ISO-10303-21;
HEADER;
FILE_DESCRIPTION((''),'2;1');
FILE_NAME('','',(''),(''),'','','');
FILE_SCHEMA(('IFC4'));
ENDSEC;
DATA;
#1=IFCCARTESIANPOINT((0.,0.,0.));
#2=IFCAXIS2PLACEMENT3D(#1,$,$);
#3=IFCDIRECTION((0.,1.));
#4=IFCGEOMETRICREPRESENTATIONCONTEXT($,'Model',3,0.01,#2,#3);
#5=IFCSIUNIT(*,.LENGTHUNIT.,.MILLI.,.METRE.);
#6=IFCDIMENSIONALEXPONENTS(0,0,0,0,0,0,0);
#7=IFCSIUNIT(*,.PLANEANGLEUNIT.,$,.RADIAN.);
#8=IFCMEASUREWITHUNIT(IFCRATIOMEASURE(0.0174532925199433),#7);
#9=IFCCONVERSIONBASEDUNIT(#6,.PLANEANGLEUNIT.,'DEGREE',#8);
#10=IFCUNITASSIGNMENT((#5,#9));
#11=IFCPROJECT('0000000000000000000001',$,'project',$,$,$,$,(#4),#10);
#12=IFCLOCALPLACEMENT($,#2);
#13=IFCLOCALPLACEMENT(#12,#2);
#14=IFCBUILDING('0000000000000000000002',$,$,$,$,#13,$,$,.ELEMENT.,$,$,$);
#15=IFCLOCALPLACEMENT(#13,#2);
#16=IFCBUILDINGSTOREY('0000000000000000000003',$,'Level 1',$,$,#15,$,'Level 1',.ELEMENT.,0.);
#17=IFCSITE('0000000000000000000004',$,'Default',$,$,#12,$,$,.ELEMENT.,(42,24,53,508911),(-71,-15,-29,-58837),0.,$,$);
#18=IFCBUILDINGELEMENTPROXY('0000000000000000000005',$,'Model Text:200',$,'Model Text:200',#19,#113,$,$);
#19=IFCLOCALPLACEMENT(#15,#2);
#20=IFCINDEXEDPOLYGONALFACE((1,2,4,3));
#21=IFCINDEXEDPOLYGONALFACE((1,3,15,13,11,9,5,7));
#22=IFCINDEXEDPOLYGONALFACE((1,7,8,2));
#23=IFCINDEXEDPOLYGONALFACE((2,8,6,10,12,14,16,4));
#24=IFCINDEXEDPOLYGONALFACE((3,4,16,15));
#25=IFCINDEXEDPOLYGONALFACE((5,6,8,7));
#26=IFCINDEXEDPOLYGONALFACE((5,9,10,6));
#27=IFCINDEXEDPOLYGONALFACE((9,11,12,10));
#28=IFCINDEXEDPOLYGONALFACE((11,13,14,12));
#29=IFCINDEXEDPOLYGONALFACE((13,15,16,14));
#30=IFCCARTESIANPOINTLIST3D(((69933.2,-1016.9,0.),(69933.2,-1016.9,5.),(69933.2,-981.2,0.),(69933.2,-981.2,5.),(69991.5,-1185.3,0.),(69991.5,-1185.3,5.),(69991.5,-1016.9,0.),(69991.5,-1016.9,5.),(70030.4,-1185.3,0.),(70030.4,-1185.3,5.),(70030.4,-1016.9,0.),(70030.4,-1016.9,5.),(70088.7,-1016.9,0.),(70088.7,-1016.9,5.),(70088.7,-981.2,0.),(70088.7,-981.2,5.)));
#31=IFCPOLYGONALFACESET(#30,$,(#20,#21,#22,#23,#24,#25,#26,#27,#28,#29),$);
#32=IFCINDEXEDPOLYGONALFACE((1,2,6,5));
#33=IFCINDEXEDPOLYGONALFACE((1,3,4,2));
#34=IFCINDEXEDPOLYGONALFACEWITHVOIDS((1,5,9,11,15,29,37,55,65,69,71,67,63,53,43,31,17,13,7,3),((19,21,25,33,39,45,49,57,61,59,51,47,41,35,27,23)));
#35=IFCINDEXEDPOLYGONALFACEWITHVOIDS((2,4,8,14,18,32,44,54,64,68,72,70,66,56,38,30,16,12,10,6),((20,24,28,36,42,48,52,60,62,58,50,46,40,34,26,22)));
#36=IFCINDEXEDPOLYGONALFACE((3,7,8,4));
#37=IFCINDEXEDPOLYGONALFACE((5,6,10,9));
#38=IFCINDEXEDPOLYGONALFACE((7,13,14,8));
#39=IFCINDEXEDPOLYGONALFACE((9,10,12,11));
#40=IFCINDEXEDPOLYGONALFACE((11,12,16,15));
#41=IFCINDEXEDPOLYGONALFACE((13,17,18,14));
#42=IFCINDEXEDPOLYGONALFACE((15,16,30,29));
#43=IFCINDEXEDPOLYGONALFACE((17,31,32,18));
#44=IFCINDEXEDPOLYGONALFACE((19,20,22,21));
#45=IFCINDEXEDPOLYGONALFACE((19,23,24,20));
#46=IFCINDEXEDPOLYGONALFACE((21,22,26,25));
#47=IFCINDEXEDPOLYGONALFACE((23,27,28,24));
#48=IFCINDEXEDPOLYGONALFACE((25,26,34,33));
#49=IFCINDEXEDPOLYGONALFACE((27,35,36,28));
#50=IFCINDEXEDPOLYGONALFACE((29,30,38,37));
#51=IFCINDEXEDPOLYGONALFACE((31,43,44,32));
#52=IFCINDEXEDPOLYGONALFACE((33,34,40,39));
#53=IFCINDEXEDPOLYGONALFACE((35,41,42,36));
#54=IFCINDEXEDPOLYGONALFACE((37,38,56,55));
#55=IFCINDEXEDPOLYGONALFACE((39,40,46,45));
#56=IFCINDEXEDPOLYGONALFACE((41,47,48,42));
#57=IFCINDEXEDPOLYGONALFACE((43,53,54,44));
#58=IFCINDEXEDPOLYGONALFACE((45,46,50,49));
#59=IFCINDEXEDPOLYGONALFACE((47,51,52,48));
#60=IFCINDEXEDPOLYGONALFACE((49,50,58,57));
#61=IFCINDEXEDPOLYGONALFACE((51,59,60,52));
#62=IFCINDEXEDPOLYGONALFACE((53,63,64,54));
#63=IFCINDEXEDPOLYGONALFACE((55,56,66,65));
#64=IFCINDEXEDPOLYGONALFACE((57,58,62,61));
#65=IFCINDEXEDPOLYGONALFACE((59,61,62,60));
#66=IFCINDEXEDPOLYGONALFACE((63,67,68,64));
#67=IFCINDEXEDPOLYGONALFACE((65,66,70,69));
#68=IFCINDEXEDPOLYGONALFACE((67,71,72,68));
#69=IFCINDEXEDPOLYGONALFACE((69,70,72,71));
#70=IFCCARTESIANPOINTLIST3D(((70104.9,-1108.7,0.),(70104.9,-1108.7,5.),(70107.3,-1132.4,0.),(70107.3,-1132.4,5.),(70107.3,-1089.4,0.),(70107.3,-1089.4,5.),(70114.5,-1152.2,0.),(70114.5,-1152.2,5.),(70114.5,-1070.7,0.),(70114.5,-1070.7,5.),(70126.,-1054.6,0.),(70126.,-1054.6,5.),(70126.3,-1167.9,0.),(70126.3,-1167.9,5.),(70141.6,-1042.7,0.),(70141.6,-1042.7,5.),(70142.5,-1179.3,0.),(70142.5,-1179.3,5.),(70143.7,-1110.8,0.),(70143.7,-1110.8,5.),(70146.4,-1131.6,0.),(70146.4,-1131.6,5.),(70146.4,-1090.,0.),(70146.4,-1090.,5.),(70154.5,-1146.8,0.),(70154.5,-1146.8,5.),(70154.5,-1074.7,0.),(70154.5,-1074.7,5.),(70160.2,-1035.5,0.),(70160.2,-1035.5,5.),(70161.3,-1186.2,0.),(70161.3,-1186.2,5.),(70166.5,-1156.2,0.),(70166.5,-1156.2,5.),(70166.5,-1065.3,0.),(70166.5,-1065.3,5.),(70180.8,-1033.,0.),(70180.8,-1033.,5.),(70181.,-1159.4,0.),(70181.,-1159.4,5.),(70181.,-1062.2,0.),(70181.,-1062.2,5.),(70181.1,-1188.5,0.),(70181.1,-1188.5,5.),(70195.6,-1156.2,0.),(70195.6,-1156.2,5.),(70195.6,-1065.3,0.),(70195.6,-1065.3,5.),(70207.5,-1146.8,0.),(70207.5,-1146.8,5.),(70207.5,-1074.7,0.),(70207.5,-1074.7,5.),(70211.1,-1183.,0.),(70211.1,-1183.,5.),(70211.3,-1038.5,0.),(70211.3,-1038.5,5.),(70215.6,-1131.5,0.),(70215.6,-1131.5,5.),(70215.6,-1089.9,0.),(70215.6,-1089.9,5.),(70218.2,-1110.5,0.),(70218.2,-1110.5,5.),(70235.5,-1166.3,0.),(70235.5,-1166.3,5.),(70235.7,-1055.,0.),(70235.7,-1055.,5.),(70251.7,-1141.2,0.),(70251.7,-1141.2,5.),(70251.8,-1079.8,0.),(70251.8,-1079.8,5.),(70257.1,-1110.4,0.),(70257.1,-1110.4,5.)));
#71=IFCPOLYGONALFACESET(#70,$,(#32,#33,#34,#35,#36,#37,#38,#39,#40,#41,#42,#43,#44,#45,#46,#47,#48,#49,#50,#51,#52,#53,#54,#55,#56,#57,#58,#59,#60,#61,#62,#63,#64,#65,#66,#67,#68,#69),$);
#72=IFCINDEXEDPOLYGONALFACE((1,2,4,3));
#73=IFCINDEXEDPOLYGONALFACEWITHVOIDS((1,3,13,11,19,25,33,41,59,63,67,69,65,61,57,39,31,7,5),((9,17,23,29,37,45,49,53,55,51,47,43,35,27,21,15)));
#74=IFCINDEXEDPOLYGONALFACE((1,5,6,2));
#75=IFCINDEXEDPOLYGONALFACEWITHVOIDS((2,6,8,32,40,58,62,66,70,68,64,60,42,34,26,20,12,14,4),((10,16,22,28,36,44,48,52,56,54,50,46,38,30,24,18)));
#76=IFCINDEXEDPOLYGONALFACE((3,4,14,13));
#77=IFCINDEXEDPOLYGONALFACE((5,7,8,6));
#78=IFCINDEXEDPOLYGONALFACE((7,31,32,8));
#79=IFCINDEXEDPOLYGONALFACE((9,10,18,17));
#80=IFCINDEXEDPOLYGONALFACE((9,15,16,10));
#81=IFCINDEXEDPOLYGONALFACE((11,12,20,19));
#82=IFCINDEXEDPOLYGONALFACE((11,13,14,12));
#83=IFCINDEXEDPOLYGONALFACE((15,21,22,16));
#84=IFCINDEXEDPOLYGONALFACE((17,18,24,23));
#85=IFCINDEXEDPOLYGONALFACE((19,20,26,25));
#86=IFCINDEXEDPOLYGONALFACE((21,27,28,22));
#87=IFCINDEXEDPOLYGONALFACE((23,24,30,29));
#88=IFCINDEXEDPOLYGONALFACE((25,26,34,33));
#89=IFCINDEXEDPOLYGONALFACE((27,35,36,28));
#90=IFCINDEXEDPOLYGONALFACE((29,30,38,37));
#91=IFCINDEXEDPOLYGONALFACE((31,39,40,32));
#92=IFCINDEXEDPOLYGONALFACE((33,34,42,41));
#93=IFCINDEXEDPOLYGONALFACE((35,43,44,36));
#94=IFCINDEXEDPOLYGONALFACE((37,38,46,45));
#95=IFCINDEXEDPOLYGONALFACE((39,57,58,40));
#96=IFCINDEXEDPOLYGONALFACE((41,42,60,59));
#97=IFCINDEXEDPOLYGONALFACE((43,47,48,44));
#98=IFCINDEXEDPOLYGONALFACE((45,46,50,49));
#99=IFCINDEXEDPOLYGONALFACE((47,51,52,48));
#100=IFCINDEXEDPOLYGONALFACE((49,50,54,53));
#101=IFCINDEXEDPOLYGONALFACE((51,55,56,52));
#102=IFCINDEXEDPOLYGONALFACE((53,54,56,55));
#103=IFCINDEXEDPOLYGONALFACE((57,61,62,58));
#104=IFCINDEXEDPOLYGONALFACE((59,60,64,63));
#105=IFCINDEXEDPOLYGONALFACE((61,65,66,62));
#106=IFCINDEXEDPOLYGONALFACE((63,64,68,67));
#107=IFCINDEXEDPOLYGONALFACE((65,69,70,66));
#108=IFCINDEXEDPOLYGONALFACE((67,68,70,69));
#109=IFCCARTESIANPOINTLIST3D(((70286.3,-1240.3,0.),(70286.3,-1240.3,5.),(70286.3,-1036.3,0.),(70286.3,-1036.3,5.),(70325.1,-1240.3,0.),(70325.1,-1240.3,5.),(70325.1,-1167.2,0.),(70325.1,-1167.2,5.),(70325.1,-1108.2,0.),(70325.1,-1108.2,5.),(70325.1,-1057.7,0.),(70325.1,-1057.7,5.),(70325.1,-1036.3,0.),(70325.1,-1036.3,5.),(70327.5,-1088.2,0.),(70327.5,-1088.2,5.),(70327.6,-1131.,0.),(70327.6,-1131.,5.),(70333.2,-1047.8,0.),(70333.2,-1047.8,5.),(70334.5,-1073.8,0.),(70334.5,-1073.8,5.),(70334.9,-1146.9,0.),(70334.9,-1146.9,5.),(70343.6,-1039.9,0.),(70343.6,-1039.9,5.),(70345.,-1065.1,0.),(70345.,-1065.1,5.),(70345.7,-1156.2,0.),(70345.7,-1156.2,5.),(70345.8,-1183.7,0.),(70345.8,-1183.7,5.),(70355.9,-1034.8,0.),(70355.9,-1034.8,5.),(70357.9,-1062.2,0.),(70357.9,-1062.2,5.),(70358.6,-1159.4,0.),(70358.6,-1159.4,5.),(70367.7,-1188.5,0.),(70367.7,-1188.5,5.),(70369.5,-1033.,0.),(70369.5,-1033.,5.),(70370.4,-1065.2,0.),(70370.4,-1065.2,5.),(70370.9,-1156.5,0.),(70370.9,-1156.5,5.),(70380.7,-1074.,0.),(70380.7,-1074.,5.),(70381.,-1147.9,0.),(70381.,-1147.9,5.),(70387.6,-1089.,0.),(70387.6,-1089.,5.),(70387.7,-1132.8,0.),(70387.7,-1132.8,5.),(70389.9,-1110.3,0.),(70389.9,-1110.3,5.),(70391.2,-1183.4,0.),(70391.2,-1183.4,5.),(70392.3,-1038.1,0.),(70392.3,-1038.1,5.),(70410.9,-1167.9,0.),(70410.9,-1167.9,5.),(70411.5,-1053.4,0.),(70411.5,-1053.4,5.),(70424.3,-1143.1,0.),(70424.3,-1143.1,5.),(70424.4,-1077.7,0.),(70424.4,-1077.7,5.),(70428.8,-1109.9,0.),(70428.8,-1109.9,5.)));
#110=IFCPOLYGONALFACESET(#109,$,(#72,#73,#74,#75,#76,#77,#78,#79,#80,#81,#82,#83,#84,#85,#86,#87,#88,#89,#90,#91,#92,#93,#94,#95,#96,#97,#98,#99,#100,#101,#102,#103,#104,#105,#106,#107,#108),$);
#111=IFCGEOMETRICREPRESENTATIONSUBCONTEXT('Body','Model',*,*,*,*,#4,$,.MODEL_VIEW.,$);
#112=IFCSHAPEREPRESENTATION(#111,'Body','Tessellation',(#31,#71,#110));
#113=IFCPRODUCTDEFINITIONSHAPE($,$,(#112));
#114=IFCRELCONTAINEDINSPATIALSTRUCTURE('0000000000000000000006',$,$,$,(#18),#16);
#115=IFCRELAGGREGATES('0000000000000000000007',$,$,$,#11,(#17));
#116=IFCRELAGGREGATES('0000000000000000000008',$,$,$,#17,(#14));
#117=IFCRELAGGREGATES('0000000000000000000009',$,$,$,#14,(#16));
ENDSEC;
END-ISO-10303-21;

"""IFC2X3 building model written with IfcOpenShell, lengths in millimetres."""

from ifc_helpers import new_model, entity, si_unit, converted_unit, direction, frame, origin, place, context, subcontext, project, spatial, polyline, outline, extrude, element, save


model = new_model("IFC2X3")

# Units and contexts
model_context = context("Model", 3, precision=0.01, world=origin(), true_north=direction((0.0, 1.0)))
body_context = subcontext(model_context, "Body", "Model", "MODEL_VIEW")
ifc_project = project(units=[si_unit("LENGTHUNIT", "METRE", prefix="MILLI"), converted_unit("PLANEANGLEUNIT", "DEGREE", entity("IfcRatioMeasure", 0.0174532925199433), si_unit("PLANEANGLEUNIT", "RADIAN"), dimensions=[0, 0, 0, 0, 0, 0, 0])], contexts=[model_context])

# Site, building, storey
site_placement = place(None, origin())
site = spatial("IfcSite", under=ifc_project, at=site_placement, Name="Default", CompositionType="ELEMENT", RefLatitude=(42, 24, 53, 508911), RefLongitude=(-71, -15, -29, -58837), RefElevation=0.0)
building_placement = place(site_placement, origin())
building = spatial("IfcBuilding", under=site, at=building_placement, CompositionType="ELEMENT")
storey_placement = place(building_placement, origin())
storey = spatial("IfcBuildingStorey", under=building, at=storey_placement, Name="Level 1", LongName="Level 1", CompositionType="ELEMENT", Elevation=0.0)

# Building element proxy
proxy_1_placement = place(storey_placement, origin())
element("IfcBuildingElementProxy", 1, at=proxy_1_placement, inside=storey, Name="Model Text:200", ObjectType="Model Text:200", context=body_context, shape_type="SweptSolid", body=[
    extrude(outline(polyline([(-19.4, -135.2), (19.4, -135.2), (19.4, 33.2), (77.7, 33.2), (77.7, 68.8), (-77.7, 68.8), (-77.7, 33.2), (-19.4, 33.2), (-19.4, -135.2)])), frame((70010.9, -1050.1, 0.0)), (0.0, 0.0, 1.0), 5.0),
    extrude(outline(polyline([(-8.8, -65.7), (15.1, -65.7), (35.5, -60.5), (52.3, -50.4), (65.3, -35.4), (74.1, -17.3), (78.4, 2.1), (75.9, 32.5), (61.8, 58.5), (38.4, 77.1), (8.3, 85.6), (-22.7, 83.3), (-49.0, 69.9), (-67.8, 47.3), (-76.3, 17.5), (-76.0, -3.3), (-70.7, -22.5), (-60.5, -39.2), (-45.5, -52.3), (-27.7, -61.4), (-8.8, -65.7)]), holes=[polyline([(-2.7, -27.2), (-23.1, -22.5), (-37.5, -12.9), (-45.7, 0.0), (-47.3, 14.8), (-42.7, 28.9), (-32.2, 39.9), (-16.3, 46.3), (4.5, 46.9), (25.1, 42.1), (39.6, 32.6), (47.7, 19.7), (49.4, 5.0), (44.8, -9.2), (34.2, -20.2), (18.2, -26.7), (-2.7, -27.2)])]), frame((70171.1, -1110.8, 0.0), z_axis=(0.0, 0.0, 1.0), x_axis=(0.100608, -0.994926, 0.0)), (0.0, 0.0, 1.0), 5.0),
    extrude(outline(polyline([(-73.1, -75.4), (130.9, -75.4), (130.9, -36.6), (57.8, -36.6), (74.3, -15.9), (79.1, 6.0), (73.9, 29.5), (58.4, 49.2), (33.6, 62.6), (0.5, 67.1), (-31.8, 62.8), (-56.1, 49.8), (-71.3, 30.7), (-76.4, 7.8), (-74.7, -5.8), (-69.6, -18.1), (-61.7, -28.5), (-51.7, -36.6), (-73.1, -36.6), (-73.1, -75.4)]), holes=[polyline([(-1.2, -36.6), (-21.2, -34.2), (-35.6, -27.2), (-44.3, -16.7), (-47.2, -3.8), (-44.3, 8.7), (-35.4, 19.0), (-20.4, 25.9), (0.8, 28.2), (23.3, 26.0), (38.5, 19.3), (47.1, 9.2), (49.9, -3.1), (46.8, -16.0), (37.4, -26.8), (21.5, -34.1), (-1.2, -36.6)])]), frame((70361.7, -1109.4, 0.0), z_axis=(0.0, 0.0, 1.0), x_axis=(0.0, -1.0, 0.0)), (0.0, 0.0, 1.0), 5.0),
])

save(model, "model.ifc")
